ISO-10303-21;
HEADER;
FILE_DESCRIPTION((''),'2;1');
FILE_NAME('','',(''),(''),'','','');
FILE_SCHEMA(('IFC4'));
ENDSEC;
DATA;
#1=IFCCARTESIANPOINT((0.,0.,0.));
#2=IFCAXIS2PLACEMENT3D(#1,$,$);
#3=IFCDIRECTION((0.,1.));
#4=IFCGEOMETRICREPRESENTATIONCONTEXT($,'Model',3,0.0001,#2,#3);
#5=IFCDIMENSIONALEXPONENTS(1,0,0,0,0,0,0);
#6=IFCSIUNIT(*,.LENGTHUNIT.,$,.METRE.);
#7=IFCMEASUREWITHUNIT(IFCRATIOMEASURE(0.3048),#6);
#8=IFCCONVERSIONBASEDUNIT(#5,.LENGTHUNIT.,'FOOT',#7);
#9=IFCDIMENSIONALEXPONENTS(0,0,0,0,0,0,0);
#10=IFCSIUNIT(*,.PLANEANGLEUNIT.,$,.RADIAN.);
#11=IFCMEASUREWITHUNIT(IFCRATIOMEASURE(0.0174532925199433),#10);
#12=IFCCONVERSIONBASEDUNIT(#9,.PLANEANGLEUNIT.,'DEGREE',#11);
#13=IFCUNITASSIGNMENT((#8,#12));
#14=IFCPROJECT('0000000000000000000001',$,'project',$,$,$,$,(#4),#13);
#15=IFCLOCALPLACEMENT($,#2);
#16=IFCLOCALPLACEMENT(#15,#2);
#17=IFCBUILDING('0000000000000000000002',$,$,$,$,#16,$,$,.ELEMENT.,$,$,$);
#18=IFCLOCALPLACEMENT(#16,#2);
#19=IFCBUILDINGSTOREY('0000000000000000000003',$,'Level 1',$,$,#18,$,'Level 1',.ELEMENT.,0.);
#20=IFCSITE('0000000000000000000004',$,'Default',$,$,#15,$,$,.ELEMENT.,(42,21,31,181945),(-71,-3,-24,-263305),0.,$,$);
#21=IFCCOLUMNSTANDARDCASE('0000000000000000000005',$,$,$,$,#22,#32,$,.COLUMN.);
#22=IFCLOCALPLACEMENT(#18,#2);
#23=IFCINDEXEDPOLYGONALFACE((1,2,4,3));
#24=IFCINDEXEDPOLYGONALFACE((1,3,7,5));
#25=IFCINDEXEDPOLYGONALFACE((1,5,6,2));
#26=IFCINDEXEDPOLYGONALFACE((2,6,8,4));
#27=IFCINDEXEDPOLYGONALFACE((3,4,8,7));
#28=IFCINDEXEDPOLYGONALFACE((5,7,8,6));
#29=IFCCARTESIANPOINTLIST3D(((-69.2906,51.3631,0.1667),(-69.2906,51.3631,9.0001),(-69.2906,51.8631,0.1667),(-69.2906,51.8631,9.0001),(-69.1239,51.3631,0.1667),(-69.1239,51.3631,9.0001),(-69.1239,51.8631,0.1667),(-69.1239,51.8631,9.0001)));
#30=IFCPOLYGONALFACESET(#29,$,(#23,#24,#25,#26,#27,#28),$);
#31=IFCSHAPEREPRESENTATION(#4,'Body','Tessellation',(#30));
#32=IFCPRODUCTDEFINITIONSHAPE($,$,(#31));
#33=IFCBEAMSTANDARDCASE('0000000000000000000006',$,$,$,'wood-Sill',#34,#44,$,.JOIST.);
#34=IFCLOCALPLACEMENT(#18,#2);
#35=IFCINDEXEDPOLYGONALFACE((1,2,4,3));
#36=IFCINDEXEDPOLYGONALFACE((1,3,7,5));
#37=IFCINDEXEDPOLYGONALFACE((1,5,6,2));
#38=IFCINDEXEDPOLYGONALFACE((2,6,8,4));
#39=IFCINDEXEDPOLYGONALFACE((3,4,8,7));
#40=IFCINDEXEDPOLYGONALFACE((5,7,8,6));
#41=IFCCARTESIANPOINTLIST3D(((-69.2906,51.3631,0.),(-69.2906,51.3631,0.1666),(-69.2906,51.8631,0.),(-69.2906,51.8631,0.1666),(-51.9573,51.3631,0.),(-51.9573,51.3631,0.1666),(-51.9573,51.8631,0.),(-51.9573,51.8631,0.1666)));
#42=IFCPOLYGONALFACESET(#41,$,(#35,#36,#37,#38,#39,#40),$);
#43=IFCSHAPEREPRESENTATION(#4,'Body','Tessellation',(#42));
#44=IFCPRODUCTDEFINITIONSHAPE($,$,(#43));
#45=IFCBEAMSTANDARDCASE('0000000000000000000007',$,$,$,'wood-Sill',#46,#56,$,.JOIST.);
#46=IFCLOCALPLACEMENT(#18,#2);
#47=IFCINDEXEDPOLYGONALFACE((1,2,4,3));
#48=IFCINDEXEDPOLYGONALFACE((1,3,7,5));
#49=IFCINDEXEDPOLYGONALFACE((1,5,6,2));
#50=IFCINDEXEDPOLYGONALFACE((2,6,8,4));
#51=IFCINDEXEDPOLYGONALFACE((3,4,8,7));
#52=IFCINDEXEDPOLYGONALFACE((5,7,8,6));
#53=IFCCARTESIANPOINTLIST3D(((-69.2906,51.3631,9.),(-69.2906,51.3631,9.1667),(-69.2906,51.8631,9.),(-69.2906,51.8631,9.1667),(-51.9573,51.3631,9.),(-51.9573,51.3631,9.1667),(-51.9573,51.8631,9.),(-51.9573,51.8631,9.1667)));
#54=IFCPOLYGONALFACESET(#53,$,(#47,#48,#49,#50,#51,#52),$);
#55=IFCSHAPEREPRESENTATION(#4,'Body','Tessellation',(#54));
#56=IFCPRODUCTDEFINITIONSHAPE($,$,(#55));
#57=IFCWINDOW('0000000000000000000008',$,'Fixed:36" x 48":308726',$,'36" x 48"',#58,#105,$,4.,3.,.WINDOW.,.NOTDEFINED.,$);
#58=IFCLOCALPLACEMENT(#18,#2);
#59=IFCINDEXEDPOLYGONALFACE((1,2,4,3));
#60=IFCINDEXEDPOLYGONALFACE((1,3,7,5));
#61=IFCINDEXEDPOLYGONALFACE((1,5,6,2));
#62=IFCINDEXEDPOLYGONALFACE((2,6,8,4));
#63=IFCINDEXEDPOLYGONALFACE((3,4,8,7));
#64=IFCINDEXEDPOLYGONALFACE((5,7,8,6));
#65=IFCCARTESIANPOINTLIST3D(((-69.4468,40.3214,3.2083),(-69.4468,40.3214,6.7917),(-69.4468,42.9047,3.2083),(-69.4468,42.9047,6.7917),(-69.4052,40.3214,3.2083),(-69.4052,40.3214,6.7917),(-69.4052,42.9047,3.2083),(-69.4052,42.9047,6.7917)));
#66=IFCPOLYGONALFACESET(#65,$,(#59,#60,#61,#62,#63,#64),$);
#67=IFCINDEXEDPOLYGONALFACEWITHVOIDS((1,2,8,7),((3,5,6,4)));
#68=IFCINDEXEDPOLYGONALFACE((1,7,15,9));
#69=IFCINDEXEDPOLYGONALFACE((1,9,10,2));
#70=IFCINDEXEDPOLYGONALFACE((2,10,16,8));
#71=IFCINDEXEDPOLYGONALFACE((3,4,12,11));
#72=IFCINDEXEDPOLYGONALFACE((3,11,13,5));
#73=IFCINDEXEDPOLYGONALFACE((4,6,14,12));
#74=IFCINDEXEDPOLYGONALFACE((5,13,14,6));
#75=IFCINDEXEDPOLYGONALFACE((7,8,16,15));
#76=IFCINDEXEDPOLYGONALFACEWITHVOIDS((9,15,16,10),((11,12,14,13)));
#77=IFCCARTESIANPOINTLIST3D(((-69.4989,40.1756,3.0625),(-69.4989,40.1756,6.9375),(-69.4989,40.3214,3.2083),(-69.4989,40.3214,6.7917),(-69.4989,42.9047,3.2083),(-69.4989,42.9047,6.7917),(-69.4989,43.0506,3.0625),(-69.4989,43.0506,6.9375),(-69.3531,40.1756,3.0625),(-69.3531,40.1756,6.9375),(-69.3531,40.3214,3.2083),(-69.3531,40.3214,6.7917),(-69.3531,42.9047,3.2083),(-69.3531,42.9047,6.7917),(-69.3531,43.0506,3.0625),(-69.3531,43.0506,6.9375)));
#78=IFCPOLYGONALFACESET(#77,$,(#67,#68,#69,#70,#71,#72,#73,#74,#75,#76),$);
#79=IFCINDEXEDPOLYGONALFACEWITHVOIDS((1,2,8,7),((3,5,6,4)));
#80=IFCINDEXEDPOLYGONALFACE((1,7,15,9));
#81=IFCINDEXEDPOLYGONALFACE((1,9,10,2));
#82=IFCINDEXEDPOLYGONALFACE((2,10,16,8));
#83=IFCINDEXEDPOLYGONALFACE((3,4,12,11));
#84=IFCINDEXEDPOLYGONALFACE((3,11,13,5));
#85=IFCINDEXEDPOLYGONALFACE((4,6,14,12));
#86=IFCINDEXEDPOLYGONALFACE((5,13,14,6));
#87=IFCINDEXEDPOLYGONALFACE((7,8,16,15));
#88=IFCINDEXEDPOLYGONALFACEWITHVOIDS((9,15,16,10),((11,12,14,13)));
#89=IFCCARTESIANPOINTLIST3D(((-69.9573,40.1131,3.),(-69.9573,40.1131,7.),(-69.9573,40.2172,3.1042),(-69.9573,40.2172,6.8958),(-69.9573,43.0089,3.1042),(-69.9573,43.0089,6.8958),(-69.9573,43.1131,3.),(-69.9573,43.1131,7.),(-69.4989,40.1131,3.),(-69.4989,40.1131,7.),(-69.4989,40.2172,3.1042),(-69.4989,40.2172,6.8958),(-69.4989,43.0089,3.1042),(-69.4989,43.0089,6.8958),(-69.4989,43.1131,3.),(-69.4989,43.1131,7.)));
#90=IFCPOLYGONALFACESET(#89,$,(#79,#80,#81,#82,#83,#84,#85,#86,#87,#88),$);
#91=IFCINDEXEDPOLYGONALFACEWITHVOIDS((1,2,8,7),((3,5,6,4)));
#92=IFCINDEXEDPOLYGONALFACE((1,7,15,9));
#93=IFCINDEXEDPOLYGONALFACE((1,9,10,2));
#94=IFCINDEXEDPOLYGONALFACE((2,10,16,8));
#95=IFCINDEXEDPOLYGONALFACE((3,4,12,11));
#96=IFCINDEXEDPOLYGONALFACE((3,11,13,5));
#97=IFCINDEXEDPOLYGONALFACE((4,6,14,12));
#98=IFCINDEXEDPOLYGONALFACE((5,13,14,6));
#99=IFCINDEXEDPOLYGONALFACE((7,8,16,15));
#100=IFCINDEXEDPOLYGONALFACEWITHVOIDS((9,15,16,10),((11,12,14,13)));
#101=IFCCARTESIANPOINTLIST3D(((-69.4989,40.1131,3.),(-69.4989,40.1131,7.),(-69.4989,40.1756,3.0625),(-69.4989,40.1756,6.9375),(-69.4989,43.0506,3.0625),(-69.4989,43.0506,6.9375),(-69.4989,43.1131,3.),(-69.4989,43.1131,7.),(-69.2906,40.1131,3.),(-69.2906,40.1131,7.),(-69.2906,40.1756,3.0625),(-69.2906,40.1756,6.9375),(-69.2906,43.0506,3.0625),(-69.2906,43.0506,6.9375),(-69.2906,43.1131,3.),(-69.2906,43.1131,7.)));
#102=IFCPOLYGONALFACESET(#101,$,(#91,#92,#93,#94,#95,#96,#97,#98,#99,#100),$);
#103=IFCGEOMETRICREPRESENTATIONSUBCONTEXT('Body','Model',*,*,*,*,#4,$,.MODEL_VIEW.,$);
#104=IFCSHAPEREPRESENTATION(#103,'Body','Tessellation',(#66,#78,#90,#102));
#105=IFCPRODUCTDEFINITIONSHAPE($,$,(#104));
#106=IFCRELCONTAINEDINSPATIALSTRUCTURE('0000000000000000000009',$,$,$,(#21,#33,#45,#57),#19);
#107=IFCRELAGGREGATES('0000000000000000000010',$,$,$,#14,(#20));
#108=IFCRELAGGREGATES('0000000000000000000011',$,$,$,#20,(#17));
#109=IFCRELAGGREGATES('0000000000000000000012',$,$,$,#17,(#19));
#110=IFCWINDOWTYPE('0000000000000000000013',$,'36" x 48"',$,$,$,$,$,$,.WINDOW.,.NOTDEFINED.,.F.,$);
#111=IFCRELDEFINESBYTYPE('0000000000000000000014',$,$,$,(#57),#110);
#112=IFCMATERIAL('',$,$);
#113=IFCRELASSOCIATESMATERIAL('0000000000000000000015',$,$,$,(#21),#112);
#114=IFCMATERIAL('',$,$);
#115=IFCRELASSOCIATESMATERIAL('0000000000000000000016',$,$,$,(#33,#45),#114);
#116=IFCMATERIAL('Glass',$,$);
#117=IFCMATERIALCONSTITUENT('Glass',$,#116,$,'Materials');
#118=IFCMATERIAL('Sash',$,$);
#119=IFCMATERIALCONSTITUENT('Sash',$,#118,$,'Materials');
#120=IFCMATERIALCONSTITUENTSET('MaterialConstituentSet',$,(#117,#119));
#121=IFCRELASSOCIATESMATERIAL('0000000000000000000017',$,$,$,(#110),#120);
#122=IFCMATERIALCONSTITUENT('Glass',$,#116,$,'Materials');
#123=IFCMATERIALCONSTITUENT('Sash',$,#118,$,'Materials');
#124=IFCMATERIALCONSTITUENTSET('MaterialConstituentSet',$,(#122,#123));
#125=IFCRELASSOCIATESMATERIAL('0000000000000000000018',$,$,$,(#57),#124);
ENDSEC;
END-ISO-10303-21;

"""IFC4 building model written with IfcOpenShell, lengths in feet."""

from ifc_helpers import new_model, entity, si_unit, converted_unit, direction, frame, frame_2d, origin, origin_with_axes, place, context, subcontext, project, spatial, polyline, rectangle, outline, extrude, source, transform, mapped, material, constituent, constituent_set, type_object, type_shapes, element, save


model = new_model("IFC4")

# Units and contexts
model_context = context("Model", 3, precision=0.0001, world=origin(), true_north=direction((0.0, 1.0)))
body_context = subcontext(model_context, "Body", "Model", "MODEL_VIEW")
ifc_project = project(units=[converted_unit("LENGTHUNIT", "FOOT", entity("IfcRatioMeasure", 0.3048), si_unit("LENGTHUNIT", "METRE"), dimensions=[1, 0, 0, 0, 0, 0, 0]), converted_unit("PLANEANGLEUNIT", "DEGREE", entity("IfcRatioMeasure", 0.0174532925199433), si_unit("PLANEANGLEUNIT", "RADIAN"), dimensions=[0, 0, 0, 0, 0, 0, 0])], contexts=[model_context])

# Site, building, storey
site_placement = place(None, origin())
site = spatial("IfcSite", under=ifc_project, at=site_placement, Name="Default", CompositionType="ELEMENT", RefLatitude=(42, 21, 31, 181945), RefLongitude=(-71, -3, -24, -263305), RefElevation=0.0)
building_placement = place(site_placement, origin())
building = spatial("IfcBuilding", under=site, at=building_placement, CompositionType="ELEMENT")
storey_placement = place(building_placement, origin())
storey = spatial("IfcBuildingStorey", under=building, at=storey_placement, Name="Level 1", LongName="Level 1", CompositionType="ELEMENT", Elevation=0.0)

# Column
placement_1 = place(storey_placement, frame((-69.6239, 19.7797, 0.0), z_axis=(0.0, 0.0, 1.0), x_axis=(0.0, 1.0, 0.0)))
ifc_material_1 = material(Name="")
placement_2 = place(storey_placement, frame((-69.2906, 51.6131, 0.0)))
for number, where, z_axis, x_axis in (
    (1, (0.0833, 0.0, 0.1667), (0.0, 0.0, 1.0), (1.0, 0.0, 0.0)),
):
    element("IfcColumnStandardCase", number, at=place(placement_2, frame(where, z_axis=z_axis, x_axis=x_axis)), inside=storey, material=ifc_material_1, PredefinedType="COLUMN", context=model_context, shape_type="SweptSolid", body=[
        extrude(rectangle(XDim=0.1667, YDim=0.5), origin(), (0.0, 0.0, 1.0), 8.8334),
    ])

# Beams
ifc_material_2 = material(Name="")
for number, where, z_axis, x_axis in (
    (2, (0.0, 0.0, 0.0833), (1.0, 0.0, 0.0), (0.0, 0.0, 1.0)),
    (3, (0.0, 0.0, 9.0834), (1.0, 0.0, 0.0), (0.0, 0.0, 1.0)),
):
    element("IfcBeamStandardCase", number, at=place(placement_2, frame(where, z_axis=z_axis, x_axis=x_axis)), inside=storey, material=ifc_material_2, ObjectType="wood-Sill", PredefinedType="JOIST", context=model_context, shape_type="SweptSolid", body=[
        extrude(rectangle(XDim=0.1667, YDim=0.5), origin_with_axes(), (0.0, 0.0, 1.0), 17.3333),
    ])

# Window
ifc_material_3 = material(Name="Glass")
ifc_constituent_1 = constituent(ifc_material_3, Name="Glass", Category="Materials")
ifc_material_4 = material(Name="Sash")
ifc_constituent_2 = constituent(ifc_material_4, Name="Sash", Category="Materials")
ifc_constituent_set_1 = constituent_set(constituents=[ifc_constituent_1, ifc_constituent_2], Name="MaterialConstituentSet")
ifc_constituent_3 = constituent(ifc_material_3, Name="Glass", Category="Materials")
ifc_constituent_4 = constituent(ifc_material_4, Name="Sash", Category="Materials")
ifc_constituent_set_2 = constituent_set(constituents=[ifc_constituent_3, ifc_constituent_4], Name="MaterialConstituentSet")
window_type = type_object("IfcWindowType", Name="36\" x 48\"", ParameterTakesPrecedence=False, PartitioningType="NOTDEFINED", PredefinedType="WINDOW", material=ifc_constituent_set_2)
shared_shape = source(origin(), body_context, "Body", "SweptSolid", [
    extrude(rectangle(XDim=0.0417, YDim=2.5833, at=frame_2d((0.0, 0.0), x_axis=(1.0, 0.0))), frame((1.5, 0.5312, 0.2083), z_axis=(0.0, 0.0, 1.0), x_axis=(0.0, 1.0, 0.0)), (0.0, 0.0, 1.0), 3.5833),
    extrude(outline(polyline([(-1.4375, -1.9375), (1.4375, -1.9375), (1.4375, 1.9375), (-1.4375, 1.9375), (-1.4375, -1.9375)]), holes=[polyline([(-1.2917, -1.7917), (-1.2917, 1.7917), (1.2917, 1.7917), (1.2917, -1.7917), (-1.2917, -1.7917)])]), frame((1.5, 0.4583, 2.0), z_axis=(0.0, 1.0, 0.0), x_axis=(1.0, 0.0, 0.0)), (0.0, 0.0, 1.0), 0.1458),
    extrude(outline(polyline([(-1.5, -2.0), (1.5, -2.0), (1.5, 2.0), (-1.5, 2.0), (-1.5, -2.0)]), holes=[polyline([(-1.3958, -1.8958), (-1.3958, 1.8958), (1.3958, 1.8958), (1.3958, -1.8958), (-1.3958, -1.8958)])]), frame((1.5, 0.0, 2.0), z_axis=(0.0, 1.0, 0.0), x_axis=(1.0, 0.0, 0.0)), (0.0, 0.0, 1.0), 0.4583),
    extrude(outline(polyline([(-2.0, -1.5), (2.0, -1.5), (2.0, 1.5), (-2.0, 1.5), (-2.0, -1.5)]), holes=[polyline([(-1.9375, -1.4375), (-1.9375, 1.4375), (1.9375, 1.4375), (1.9375, -1.4375), (-1.9375, -1.4375)])]), frame((1.5, 0.4583, 2.0), z_axis=(0.0, 1.0, 0.0), x_axis=(0.0, 0.0, -1.0)), (0.0, 0.0, 1.0), 0.2083),
])
type_shapes(window_type, [shared_shape])
placement_3 = place(placement_1, frame((23.3333, 0.3333, 3.0)))
window_placement = place(placement_3, frame((0.0, 0.0, 0.0), z_axis=(0.0, 0.0, 1.0), x_axis=(-1.0, 0.0, 0.0)))
element("IfcWindow", 4, at=window_placement, inside=storey, type_object=window_type, material=ifc_constituent_set_1, Name="Fixed:36\" x 48\":308726", ObjectType="36\" x 48\"", OverallHeight=4.0, OverallWidth=3.0, PartitioningType="NOTDEFINED", PredefinedType="WINDOW", context=body_context, shape_type="MappedRepresentation", body=[
    mapped(shared_shape, transform((0.0, 0.0, 0.0), scale=1.0)),
])

save(model, "model.ifc")
